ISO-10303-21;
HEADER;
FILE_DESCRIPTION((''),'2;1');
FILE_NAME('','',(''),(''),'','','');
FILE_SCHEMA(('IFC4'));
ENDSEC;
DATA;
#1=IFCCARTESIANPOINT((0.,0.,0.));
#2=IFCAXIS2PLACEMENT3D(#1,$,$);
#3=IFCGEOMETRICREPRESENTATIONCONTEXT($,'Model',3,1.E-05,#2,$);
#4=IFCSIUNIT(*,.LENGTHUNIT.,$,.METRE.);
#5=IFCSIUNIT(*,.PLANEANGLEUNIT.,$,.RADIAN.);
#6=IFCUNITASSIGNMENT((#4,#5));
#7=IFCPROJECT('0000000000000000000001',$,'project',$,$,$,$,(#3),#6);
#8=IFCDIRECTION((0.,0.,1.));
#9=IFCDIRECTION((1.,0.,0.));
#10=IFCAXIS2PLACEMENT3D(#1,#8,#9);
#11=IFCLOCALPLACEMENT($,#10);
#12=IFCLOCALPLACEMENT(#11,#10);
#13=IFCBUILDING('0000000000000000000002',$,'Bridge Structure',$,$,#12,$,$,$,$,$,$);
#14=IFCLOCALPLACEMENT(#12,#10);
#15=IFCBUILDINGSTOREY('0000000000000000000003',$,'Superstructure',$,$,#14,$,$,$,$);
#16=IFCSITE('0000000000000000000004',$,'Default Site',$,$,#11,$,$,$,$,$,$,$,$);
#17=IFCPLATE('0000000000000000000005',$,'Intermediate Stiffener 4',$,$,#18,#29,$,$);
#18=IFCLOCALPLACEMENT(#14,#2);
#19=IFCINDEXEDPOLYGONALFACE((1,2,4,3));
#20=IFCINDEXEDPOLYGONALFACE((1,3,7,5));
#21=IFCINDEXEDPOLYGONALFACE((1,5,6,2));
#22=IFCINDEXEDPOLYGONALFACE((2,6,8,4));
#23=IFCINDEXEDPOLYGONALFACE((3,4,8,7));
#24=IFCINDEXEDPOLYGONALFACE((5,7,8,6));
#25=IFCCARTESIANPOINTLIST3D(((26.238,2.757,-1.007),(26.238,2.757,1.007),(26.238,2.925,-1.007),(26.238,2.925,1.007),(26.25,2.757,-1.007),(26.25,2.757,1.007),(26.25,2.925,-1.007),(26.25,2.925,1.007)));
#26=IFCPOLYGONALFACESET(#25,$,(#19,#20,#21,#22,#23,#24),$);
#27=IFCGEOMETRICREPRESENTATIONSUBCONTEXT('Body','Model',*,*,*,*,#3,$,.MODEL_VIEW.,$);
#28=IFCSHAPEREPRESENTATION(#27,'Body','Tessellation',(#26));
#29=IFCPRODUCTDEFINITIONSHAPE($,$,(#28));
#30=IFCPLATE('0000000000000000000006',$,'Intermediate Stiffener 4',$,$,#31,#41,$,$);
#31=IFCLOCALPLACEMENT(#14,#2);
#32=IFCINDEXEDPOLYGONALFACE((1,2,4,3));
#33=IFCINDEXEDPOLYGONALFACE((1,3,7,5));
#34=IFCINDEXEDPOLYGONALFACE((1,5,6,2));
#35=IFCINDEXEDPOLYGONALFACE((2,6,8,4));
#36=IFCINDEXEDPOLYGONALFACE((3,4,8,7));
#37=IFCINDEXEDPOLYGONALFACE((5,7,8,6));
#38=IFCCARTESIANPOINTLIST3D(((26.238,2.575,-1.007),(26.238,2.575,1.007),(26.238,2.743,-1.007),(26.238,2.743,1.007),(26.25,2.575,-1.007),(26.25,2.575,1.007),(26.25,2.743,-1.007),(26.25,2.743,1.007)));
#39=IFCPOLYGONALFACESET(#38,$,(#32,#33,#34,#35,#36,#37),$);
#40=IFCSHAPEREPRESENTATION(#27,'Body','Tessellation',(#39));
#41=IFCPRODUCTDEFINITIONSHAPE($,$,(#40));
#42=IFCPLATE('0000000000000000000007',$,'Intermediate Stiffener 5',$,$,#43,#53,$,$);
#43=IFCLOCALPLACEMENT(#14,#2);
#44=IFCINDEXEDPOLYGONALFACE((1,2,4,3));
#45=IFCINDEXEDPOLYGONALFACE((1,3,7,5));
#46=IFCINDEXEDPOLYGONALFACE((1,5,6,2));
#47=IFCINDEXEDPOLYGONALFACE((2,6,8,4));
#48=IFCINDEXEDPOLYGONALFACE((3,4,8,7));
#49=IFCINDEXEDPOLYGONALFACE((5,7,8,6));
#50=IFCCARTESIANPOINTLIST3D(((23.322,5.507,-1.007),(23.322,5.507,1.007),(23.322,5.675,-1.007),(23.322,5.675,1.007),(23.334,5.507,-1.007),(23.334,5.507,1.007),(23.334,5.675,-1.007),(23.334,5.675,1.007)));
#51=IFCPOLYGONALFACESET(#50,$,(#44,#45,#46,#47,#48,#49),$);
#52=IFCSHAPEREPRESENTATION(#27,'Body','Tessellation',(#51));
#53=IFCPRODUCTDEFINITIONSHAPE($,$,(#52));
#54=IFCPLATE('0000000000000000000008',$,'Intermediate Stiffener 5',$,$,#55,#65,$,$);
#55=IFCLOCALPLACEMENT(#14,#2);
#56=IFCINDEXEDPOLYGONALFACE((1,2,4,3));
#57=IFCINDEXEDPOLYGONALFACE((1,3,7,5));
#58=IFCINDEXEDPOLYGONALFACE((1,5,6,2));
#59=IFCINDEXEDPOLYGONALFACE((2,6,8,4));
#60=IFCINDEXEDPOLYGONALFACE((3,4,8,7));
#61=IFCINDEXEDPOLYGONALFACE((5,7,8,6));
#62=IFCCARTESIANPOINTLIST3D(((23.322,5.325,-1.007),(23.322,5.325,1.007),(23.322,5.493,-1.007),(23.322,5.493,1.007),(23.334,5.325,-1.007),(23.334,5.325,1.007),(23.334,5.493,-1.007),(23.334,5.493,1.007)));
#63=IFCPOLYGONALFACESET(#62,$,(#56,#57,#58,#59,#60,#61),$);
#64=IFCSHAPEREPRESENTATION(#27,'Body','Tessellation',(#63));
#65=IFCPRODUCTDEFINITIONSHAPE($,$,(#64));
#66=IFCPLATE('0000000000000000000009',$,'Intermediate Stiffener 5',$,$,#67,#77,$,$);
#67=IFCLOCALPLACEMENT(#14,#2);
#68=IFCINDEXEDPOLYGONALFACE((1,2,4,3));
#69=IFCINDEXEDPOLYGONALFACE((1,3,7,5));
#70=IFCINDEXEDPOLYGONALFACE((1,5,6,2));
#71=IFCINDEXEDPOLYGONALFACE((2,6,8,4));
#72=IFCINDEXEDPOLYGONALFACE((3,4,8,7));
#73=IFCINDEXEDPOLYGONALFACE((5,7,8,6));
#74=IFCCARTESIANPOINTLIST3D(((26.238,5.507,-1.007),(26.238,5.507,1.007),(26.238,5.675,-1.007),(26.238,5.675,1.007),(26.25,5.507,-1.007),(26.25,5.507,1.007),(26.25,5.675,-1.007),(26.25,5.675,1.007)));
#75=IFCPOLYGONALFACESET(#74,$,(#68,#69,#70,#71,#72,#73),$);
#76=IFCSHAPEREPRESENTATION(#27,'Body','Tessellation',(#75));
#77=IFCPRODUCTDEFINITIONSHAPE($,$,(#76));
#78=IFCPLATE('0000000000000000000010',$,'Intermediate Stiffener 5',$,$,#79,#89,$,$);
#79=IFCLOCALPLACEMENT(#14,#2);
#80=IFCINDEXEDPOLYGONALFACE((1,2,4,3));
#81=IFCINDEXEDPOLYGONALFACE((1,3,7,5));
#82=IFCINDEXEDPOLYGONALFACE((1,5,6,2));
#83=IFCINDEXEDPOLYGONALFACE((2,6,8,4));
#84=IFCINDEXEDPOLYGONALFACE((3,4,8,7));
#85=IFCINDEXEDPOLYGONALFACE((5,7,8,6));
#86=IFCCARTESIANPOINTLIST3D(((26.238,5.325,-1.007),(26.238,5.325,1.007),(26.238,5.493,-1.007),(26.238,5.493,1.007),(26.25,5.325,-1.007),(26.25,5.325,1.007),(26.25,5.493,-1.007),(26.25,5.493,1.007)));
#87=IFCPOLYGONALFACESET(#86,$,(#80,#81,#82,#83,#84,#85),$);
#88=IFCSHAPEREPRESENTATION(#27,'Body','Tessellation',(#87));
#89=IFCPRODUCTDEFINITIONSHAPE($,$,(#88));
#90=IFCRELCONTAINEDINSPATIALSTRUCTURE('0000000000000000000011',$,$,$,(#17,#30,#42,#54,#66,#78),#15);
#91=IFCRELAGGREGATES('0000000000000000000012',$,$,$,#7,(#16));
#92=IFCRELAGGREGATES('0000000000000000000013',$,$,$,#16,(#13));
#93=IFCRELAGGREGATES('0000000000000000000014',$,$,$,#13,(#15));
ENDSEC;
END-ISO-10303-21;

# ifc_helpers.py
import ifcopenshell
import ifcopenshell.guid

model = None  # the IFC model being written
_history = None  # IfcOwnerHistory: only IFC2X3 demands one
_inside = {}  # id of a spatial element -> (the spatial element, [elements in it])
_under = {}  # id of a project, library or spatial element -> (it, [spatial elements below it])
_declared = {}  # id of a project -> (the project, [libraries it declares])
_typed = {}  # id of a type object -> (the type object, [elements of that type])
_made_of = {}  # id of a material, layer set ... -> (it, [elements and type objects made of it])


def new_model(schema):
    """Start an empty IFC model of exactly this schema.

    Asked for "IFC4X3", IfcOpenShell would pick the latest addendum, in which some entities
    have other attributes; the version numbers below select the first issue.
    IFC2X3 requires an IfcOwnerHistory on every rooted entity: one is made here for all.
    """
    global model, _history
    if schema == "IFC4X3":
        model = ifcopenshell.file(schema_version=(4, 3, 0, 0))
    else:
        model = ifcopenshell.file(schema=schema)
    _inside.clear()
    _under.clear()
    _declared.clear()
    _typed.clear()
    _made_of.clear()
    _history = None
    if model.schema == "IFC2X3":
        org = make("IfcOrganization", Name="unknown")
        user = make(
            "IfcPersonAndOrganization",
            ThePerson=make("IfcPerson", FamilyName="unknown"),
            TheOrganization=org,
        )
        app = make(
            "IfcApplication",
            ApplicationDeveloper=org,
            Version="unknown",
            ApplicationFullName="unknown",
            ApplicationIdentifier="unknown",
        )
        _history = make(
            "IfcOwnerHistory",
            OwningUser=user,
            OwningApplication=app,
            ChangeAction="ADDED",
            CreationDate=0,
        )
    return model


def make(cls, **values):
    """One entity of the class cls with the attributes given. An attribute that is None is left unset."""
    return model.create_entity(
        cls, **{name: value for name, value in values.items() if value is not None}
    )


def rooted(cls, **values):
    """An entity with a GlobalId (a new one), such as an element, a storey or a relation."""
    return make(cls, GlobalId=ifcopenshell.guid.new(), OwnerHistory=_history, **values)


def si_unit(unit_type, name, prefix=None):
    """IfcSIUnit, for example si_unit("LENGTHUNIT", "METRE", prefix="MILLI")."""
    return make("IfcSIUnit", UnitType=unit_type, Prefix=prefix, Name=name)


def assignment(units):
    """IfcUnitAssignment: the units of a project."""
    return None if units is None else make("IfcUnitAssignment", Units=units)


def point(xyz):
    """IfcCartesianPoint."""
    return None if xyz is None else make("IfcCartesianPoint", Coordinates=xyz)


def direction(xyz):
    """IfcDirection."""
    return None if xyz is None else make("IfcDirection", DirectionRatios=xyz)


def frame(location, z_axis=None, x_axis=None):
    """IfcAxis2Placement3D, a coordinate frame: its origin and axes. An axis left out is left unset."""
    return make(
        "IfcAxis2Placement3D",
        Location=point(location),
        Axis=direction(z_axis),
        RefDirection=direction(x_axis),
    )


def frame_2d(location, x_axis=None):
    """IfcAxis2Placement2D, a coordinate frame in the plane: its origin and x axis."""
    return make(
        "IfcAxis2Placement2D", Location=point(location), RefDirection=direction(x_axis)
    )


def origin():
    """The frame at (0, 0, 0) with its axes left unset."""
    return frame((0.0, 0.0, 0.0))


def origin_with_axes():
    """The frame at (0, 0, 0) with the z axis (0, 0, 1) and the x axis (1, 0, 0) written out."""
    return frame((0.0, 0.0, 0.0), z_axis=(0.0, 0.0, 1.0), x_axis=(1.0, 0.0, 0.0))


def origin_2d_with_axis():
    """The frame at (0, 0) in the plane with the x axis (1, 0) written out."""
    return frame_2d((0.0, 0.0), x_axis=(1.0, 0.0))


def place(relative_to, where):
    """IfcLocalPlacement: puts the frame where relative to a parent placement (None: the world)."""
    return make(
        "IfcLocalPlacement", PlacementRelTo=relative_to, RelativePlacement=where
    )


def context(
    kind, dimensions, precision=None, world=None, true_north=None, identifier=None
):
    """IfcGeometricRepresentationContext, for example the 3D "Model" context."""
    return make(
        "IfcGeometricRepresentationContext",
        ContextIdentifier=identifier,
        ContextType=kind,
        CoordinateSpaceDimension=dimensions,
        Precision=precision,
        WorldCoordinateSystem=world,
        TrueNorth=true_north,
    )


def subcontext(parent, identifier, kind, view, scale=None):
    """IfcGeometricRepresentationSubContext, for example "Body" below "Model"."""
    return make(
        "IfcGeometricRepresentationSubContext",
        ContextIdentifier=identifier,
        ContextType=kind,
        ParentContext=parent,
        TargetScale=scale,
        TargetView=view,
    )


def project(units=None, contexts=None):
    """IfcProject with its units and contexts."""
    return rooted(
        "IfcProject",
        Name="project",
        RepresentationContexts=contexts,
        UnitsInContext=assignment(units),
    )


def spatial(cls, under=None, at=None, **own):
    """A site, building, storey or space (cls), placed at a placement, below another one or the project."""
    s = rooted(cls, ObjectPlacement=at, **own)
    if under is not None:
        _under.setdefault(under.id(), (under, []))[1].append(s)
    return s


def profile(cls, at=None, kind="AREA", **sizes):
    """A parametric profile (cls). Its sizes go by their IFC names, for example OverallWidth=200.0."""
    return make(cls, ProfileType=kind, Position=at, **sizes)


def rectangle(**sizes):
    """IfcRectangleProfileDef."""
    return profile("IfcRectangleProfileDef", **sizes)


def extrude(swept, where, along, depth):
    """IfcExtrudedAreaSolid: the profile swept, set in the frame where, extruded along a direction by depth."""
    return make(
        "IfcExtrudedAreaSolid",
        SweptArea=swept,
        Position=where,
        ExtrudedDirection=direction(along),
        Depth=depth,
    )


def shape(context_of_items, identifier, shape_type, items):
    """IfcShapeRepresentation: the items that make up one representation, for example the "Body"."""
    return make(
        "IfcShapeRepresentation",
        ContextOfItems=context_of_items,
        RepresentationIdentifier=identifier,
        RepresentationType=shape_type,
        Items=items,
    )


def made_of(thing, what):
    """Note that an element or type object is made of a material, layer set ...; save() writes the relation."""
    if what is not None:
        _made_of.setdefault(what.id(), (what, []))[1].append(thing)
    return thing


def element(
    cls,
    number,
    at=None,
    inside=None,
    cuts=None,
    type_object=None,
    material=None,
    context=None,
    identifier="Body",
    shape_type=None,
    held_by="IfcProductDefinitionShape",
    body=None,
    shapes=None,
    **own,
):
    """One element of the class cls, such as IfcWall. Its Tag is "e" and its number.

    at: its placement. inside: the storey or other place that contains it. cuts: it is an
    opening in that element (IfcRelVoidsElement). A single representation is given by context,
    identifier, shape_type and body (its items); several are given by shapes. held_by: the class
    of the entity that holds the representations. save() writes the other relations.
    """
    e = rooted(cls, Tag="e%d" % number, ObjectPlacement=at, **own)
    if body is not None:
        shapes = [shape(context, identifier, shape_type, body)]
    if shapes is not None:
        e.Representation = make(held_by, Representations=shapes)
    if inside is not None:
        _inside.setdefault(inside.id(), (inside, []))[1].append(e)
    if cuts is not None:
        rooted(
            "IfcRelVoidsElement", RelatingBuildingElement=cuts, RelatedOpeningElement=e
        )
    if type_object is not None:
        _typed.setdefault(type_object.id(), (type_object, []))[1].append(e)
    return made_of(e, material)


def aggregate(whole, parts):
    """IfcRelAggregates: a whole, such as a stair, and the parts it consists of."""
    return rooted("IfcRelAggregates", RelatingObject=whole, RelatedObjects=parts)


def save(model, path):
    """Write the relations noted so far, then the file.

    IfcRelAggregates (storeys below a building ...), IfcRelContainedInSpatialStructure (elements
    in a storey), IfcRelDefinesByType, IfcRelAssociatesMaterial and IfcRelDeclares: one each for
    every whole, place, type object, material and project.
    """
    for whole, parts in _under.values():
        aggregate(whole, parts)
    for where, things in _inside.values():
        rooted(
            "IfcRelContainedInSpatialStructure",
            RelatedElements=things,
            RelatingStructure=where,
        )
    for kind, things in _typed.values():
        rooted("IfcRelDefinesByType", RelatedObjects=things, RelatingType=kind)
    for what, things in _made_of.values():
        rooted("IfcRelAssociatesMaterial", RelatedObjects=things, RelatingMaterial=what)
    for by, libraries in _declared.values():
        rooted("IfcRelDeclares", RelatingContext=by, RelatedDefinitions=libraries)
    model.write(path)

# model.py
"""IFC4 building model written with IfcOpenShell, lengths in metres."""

from ifc_helpers import new_model, si_unit, frame, origin, origin_with_axes, origin_2d_with_axis, place, context, subcontext, project, spatial, rectangle, extrude, element, save


model = new_model("IFC4")

# Units and contexts
model_context = context("Model", 3, precision=1e-05, world=origin())
body_context = subcontext(model_context, "Body", "Model", "MODEL_VIEW")
ifc_project = project(units=[si_unit("LENGTHUNIT", "METRE"), si_unit("PLANEANGLEUNIT", "RADIAN")], contexts=[model_context])

# Site, building, storey
site_placement = place(None, origin_with_axes())
site = spatial("IfcSite", under=ifc_project, at=site_placement, Name="Default Site")
building_placement = place(site_placement, origin_with_axes())
building = spatial("IfcBuilding", under=site, at=building_placement, Name="Bridge Structure")
storey_placement = place(building_placement, origin_with_axes())
storey = spatial("IfcBuildingStorey", under=building, at=storey_placement, Name="Superstructure")

# Plates
for number, where, z_axis, x_axis, name in (
    (1, (26.244, 2.841, -1.007), (0.0, 0.0, 1.0), (1.0, 0.0, 0.0), "Intermediate Stiffener 4"),
    (2, (26.244, 2.659, -1.007), (0.0, 0.0, 1.0), (1.0, 0.0, 0.0), "Intermediate Stiffener 4"),
    (3, (23.328, 5.591, -1.007), (0.0, 0.0, 1.0), (1.0, 0.0, 0.0), "Intermediate Stiffener 5"),
    (4, (23.328, 5.409, -1.007), (0.0, 0.0, 1.0), (1.0, 0.0, 0.0), "Intermediate Stiffener 5"),
    (5, (26.244, 5.591, -1.007), (0.0, 0.0, 1.0), (1.0, 0.0, 0.0), "Intermediate Stiffener 5"),
    (6, (26.244, 5.409, -1.007), (0.0, 0.0, 1.0), (1.0, 0.0, 0.0), "Intermediate Stiffener 5"),
):
    element("IfcPlate", number, at=place(storey_placement, frame(where, z_axis=z_axis, x_axis=x_axis)), inside=storey, Name=name, context=body_context, shape_type="SweptSolid", body=[
        extrude(rectangle(XDim=0.012, YDim=0.168, at=origin_2d_with_axis()), origin_with_axes(), (0.0, 0.0, 1.0), 2.014),
    ])

save(model, "model.ifc")
